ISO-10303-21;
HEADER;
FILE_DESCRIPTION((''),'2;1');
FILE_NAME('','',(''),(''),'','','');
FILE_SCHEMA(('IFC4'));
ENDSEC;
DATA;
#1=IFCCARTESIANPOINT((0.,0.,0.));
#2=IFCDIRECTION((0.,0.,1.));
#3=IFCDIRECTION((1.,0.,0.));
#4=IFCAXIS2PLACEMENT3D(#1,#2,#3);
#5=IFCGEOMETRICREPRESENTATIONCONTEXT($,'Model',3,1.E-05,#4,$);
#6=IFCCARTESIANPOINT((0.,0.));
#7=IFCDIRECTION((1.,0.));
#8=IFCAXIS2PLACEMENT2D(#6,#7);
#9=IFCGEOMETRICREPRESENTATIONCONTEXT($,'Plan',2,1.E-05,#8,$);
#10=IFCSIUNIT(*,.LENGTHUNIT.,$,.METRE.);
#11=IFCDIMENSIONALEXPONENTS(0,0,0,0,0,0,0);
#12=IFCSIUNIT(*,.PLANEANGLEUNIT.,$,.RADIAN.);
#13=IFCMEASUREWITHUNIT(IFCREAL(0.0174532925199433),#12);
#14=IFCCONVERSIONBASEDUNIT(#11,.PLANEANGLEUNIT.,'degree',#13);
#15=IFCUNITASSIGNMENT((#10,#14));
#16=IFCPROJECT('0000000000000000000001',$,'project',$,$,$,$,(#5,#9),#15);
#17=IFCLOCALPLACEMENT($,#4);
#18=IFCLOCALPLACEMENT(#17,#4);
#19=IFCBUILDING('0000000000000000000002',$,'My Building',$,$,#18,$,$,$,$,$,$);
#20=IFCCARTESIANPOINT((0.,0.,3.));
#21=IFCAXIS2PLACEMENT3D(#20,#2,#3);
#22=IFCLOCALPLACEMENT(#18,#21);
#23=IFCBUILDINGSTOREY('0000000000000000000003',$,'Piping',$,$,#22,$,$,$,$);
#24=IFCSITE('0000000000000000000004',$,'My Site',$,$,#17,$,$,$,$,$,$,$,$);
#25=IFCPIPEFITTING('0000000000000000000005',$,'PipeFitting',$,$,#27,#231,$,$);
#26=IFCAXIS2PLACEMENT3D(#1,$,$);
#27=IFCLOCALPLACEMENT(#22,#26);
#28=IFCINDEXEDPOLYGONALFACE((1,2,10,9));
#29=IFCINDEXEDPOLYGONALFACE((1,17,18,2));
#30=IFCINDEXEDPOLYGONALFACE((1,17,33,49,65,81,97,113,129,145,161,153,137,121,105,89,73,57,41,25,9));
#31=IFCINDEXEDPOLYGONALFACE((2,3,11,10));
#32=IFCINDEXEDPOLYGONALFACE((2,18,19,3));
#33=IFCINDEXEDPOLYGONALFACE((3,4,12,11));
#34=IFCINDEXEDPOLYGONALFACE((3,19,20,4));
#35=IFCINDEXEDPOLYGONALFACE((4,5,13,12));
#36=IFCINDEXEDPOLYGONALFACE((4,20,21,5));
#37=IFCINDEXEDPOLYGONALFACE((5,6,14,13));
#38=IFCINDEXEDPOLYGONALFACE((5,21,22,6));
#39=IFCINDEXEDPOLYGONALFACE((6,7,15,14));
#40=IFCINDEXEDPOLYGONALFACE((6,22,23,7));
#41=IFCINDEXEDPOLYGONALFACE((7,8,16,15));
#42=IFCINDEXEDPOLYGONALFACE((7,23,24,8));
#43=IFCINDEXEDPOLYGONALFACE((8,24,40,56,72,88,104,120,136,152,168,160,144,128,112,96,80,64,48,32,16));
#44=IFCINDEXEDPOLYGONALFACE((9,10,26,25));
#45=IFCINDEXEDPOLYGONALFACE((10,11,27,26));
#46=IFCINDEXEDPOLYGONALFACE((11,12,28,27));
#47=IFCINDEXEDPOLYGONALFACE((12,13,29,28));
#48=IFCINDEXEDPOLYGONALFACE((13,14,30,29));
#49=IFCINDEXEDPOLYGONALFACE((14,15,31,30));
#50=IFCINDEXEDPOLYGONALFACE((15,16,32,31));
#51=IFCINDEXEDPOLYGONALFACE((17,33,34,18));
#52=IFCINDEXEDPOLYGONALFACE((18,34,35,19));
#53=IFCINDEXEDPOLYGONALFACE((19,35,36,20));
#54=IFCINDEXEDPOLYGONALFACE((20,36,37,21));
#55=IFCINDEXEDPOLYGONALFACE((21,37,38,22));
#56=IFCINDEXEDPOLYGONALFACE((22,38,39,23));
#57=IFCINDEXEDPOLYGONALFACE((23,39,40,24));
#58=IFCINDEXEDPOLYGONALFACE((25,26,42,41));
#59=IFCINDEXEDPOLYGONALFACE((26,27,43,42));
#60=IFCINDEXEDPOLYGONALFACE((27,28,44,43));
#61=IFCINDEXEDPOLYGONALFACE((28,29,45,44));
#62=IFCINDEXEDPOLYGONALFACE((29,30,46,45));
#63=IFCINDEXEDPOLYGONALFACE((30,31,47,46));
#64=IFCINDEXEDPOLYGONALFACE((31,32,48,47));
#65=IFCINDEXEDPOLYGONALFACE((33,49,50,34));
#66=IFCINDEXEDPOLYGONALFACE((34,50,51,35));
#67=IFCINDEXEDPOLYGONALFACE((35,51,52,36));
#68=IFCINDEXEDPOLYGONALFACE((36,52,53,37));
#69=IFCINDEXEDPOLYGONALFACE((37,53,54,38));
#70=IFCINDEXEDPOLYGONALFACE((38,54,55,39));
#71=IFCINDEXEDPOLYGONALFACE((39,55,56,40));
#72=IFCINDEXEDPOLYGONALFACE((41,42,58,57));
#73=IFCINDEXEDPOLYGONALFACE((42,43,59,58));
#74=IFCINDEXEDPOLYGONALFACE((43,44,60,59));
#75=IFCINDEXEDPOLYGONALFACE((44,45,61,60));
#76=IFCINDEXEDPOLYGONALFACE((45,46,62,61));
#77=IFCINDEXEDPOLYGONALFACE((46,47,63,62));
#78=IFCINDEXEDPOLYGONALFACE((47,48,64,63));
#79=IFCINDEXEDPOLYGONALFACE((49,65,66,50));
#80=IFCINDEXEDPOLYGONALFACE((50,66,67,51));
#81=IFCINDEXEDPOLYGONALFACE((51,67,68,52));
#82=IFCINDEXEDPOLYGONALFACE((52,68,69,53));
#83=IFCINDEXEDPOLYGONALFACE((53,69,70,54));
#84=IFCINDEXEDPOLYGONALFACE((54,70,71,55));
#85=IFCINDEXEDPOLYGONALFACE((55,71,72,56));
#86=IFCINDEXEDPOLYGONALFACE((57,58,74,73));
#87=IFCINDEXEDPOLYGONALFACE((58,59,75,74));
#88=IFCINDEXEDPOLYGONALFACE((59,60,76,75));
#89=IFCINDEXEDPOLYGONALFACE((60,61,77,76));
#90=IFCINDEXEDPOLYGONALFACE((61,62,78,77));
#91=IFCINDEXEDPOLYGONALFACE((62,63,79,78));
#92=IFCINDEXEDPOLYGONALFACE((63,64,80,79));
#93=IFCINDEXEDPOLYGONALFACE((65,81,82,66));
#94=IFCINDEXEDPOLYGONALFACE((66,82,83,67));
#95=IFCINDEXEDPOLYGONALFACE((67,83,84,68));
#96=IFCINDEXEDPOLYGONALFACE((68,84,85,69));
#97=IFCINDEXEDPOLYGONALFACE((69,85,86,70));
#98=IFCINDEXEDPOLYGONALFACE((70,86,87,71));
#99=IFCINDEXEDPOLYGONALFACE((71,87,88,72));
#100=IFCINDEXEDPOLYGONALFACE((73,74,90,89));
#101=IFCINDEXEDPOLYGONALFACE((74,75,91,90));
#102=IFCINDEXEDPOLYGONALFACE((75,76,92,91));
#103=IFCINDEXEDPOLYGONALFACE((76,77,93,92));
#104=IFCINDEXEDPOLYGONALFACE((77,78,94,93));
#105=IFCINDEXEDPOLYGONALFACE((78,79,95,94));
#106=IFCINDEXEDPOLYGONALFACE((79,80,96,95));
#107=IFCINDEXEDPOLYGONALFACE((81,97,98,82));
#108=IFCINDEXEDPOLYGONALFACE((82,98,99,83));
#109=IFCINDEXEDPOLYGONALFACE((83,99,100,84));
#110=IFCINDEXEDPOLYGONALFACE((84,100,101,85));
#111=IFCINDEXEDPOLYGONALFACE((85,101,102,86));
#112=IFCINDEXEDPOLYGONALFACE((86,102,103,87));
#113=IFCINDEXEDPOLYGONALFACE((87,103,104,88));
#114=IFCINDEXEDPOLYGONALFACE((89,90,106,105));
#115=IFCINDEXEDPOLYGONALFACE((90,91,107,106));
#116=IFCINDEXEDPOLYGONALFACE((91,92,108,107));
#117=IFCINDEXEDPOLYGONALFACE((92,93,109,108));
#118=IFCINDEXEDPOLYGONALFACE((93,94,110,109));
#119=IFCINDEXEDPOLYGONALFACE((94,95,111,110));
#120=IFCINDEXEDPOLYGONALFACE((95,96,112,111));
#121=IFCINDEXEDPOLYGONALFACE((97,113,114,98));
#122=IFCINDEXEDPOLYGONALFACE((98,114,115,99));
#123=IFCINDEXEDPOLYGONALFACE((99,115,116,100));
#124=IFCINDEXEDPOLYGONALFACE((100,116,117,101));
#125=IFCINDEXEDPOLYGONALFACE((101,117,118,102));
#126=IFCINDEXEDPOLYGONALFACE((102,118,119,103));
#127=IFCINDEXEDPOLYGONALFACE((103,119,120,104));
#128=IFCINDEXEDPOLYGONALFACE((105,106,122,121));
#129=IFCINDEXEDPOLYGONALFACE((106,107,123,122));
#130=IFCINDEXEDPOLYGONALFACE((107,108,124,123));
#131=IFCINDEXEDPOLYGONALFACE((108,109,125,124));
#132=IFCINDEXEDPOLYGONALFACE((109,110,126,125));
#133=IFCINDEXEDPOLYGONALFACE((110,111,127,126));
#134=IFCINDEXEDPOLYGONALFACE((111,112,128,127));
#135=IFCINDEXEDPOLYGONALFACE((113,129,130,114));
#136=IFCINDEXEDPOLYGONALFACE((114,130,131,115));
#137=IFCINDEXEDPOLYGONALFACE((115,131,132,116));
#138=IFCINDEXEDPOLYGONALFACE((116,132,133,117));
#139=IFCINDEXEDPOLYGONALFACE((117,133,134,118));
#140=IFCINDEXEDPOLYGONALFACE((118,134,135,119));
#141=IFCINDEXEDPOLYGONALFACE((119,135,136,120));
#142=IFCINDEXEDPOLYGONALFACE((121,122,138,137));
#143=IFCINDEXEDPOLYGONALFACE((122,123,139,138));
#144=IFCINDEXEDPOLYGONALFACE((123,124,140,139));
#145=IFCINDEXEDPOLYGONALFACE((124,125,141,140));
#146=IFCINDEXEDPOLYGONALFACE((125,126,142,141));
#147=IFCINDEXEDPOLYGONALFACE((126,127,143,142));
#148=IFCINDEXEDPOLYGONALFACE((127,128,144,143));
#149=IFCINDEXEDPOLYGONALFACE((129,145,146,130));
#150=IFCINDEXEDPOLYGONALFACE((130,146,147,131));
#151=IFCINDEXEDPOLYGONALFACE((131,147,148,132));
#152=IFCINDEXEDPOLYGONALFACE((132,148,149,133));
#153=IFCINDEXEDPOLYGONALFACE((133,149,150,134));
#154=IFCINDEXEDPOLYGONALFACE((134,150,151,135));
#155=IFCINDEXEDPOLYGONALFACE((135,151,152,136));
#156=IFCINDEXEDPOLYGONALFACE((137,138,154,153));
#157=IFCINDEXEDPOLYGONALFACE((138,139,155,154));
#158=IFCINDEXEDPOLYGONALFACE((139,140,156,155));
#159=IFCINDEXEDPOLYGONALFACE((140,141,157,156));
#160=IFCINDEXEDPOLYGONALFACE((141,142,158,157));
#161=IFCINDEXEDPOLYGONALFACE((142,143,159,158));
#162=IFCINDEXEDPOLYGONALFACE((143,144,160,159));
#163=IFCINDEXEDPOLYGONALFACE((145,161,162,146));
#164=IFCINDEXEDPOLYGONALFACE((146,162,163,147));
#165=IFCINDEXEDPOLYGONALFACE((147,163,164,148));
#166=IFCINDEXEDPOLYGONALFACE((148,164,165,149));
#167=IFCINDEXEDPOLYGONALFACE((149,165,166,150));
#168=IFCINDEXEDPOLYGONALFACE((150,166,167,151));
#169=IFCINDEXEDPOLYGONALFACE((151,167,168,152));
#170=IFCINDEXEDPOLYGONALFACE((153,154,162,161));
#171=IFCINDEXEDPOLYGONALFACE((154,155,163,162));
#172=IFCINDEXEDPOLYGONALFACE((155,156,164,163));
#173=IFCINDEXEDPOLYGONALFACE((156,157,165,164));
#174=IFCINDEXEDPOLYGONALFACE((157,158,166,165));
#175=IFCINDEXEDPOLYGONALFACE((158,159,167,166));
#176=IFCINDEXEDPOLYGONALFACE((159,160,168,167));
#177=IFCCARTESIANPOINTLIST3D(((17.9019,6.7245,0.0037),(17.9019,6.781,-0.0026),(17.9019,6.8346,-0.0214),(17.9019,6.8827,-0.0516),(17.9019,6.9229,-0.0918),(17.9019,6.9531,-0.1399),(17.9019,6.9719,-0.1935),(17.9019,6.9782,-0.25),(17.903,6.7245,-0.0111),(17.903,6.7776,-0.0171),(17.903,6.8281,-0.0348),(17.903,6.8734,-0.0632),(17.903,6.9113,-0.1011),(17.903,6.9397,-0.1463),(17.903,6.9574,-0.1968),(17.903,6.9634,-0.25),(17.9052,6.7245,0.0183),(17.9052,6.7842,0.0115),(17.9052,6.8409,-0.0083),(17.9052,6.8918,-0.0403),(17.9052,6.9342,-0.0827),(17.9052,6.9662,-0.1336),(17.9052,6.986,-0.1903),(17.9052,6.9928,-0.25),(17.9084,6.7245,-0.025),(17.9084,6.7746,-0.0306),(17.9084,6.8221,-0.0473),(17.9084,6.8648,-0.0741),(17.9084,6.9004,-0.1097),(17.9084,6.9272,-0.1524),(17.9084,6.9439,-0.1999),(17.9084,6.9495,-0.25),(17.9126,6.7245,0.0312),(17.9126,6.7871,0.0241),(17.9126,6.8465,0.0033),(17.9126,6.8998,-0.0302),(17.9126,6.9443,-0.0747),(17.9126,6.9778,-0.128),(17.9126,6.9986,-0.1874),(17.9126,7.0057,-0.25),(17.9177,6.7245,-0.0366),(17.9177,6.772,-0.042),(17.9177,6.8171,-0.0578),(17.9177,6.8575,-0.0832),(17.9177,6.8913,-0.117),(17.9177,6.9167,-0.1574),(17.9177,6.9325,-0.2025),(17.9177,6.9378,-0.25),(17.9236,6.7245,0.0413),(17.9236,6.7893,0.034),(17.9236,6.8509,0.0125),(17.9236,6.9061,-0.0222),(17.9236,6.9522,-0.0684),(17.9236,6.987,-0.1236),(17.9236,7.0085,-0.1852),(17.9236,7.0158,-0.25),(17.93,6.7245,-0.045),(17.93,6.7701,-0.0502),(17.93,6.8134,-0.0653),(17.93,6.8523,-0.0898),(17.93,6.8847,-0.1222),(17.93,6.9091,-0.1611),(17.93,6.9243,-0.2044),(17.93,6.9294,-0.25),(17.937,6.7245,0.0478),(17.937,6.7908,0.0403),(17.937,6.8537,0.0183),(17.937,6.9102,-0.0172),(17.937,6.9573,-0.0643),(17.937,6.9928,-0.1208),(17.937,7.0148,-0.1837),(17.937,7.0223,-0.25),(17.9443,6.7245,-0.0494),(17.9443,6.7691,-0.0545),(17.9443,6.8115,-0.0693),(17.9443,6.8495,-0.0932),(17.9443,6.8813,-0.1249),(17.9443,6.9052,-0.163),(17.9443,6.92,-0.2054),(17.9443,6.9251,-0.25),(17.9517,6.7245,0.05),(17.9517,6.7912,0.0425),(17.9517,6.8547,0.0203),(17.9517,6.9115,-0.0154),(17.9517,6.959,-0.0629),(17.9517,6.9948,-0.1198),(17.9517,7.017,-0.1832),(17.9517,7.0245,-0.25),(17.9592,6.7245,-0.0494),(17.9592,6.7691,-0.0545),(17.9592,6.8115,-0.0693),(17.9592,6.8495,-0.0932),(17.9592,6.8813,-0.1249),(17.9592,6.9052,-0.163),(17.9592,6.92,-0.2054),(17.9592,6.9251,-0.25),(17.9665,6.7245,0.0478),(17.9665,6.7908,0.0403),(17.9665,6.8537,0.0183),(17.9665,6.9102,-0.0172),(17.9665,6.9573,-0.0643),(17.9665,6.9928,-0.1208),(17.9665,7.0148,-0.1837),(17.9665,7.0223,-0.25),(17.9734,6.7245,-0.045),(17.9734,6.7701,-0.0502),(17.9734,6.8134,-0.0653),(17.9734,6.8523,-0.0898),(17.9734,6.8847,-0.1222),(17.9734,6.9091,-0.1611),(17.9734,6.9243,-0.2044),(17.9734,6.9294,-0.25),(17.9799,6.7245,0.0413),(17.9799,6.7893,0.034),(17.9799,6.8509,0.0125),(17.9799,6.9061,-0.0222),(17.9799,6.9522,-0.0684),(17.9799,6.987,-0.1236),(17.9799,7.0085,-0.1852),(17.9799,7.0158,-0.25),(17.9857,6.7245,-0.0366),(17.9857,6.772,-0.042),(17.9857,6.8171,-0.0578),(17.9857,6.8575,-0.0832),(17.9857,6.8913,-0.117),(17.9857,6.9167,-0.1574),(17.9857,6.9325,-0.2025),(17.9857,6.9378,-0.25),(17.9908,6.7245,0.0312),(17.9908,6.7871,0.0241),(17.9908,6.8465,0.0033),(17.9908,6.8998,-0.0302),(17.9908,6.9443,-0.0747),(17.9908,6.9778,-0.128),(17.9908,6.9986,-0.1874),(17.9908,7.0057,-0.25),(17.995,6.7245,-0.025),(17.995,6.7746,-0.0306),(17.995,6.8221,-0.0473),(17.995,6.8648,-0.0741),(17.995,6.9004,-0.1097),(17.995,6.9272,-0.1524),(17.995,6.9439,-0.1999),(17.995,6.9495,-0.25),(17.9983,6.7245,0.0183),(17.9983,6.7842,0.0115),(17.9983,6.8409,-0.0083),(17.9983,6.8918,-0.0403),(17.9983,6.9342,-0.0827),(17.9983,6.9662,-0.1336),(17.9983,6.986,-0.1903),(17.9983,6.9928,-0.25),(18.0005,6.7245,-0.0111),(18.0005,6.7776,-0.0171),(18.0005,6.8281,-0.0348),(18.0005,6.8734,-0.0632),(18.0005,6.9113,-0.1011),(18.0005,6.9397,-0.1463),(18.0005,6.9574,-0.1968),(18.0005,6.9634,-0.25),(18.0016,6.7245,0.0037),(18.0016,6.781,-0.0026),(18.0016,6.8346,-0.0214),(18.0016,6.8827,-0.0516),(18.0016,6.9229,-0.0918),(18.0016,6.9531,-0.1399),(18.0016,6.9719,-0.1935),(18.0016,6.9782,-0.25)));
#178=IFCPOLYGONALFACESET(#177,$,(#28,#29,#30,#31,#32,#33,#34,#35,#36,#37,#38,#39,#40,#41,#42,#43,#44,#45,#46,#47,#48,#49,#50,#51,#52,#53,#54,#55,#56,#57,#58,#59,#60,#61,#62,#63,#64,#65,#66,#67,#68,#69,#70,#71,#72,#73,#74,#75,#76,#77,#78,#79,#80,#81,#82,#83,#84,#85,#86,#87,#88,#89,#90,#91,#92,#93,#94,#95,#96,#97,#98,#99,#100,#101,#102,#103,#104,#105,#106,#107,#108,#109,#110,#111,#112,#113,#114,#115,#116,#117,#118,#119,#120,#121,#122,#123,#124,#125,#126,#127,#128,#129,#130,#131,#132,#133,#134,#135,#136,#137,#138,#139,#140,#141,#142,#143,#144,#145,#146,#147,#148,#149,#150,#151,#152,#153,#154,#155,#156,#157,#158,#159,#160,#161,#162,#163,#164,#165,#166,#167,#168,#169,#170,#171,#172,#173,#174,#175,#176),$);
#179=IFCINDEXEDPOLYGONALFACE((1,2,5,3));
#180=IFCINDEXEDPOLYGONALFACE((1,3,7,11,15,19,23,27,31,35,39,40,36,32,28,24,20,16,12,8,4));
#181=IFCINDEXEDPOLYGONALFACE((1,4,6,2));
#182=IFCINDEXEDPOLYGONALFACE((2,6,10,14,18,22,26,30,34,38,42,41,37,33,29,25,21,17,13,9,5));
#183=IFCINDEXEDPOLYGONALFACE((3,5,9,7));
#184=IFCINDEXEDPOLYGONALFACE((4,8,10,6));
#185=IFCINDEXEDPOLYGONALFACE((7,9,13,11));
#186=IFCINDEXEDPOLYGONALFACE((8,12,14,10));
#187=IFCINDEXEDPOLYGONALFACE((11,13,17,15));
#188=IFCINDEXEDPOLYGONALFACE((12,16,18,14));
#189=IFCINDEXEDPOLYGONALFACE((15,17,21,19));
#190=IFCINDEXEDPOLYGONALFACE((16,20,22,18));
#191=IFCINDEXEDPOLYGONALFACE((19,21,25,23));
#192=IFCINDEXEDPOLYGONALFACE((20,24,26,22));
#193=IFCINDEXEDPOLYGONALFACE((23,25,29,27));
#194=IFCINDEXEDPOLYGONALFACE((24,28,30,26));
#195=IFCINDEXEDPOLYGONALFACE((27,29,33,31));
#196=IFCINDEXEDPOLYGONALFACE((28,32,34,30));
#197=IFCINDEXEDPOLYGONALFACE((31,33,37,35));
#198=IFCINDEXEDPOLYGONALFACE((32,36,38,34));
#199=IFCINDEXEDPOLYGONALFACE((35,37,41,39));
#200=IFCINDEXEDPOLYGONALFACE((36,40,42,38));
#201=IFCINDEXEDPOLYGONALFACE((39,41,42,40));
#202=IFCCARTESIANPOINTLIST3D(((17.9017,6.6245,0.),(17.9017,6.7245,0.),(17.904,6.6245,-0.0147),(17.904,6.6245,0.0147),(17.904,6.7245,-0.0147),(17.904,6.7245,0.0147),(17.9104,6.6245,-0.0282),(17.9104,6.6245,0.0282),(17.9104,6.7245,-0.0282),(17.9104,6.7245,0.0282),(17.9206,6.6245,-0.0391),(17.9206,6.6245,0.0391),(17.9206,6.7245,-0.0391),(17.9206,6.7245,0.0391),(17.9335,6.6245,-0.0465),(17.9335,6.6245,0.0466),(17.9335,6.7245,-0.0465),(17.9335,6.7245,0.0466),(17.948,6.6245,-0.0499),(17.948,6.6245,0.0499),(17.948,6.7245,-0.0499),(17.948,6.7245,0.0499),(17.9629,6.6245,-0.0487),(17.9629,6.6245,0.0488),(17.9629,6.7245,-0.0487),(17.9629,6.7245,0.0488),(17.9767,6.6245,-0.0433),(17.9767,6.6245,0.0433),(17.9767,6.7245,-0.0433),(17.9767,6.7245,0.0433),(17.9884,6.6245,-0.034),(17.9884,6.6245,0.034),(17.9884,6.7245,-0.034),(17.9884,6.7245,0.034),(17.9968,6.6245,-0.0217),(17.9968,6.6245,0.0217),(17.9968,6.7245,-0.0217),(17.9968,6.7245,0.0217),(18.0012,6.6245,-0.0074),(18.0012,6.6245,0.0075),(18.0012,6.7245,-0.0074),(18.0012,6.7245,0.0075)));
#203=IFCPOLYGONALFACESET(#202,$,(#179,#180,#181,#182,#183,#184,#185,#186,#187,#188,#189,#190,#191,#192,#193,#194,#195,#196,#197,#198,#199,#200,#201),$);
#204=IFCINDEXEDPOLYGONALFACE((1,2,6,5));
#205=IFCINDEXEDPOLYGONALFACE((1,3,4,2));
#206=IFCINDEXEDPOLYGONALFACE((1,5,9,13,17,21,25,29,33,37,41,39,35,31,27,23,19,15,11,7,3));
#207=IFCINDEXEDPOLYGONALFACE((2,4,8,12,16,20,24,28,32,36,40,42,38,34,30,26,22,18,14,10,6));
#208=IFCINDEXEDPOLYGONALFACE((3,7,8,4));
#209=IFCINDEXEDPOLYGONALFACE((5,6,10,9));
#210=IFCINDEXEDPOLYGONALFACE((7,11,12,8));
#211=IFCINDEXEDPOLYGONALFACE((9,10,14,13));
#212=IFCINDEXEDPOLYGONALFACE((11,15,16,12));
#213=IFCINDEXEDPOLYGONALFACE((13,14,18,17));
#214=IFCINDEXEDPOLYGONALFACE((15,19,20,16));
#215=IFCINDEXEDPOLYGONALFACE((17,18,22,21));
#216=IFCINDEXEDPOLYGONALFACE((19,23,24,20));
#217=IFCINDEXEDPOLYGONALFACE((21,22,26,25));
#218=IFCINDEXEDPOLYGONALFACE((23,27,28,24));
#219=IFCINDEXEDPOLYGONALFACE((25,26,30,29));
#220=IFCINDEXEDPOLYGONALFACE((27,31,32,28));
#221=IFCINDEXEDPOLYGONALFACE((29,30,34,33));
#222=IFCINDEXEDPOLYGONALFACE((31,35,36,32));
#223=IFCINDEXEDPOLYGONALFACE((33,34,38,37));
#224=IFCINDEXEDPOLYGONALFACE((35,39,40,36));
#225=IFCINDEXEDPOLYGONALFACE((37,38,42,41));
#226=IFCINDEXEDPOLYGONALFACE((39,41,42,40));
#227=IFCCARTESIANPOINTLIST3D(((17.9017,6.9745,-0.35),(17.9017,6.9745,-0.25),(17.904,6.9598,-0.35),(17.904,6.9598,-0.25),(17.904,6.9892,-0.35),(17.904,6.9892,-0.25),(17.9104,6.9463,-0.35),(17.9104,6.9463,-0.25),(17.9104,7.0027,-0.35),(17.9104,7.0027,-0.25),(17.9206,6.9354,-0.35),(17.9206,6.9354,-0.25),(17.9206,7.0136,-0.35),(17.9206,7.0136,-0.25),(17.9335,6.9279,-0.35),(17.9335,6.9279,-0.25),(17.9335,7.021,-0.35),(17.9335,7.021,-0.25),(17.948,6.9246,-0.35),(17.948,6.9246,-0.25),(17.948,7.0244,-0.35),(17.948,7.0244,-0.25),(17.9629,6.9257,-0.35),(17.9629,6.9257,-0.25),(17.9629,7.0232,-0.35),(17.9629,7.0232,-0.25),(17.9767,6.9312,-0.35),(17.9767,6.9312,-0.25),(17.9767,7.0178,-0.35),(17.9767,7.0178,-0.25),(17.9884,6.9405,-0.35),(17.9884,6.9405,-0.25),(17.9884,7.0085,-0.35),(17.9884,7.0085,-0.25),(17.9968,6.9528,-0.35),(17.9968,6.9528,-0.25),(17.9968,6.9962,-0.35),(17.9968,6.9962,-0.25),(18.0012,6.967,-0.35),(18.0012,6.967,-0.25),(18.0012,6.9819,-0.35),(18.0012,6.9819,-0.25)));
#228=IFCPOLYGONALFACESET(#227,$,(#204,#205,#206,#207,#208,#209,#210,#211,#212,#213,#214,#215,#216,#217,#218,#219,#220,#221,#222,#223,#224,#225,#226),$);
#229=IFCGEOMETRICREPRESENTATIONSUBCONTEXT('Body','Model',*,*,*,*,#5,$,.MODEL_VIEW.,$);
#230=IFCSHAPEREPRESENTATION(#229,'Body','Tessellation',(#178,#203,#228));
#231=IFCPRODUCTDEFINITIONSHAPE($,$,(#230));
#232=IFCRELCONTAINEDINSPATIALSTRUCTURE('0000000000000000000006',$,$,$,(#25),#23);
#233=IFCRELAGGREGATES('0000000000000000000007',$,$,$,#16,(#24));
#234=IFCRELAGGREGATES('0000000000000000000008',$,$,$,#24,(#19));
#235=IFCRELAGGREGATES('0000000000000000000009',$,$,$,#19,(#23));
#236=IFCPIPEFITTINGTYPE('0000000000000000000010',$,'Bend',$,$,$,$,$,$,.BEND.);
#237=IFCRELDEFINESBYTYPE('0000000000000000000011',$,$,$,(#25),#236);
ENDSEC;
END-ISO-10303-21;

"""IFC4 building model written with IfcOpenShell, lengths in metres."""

from ifc_helpers import new_model, entity, si_unit, converted_unit, frame, origin_with_axes, origin_2d_with_axis, place, context, subcontext, project, spatial, circle, extrude, source, transform, mapped, type_object, type_shapes, element, save


model = new_model("IFC4")

# Units and contexts
model_context = context("Model", 3, precision=1e-05, world=origin_with_axes())
plan_context = context("Plan", 2, precision=1e-05, world=origin_2d_with_axis())
body_context = subcontext(model_context, "Body", "Model", "MODEL_VIEW")
ifc_project = project(units=[si_unit("LENGTHUNIT", "METRE"), converted_unit("PLANEANGLEUNIT", "degree", entity("IfcReal", 0.0174532925199433), si_unit("PLANEANGLEUNIT", "RADIAN"), dimensions=[0, 0, 0, 0, 0, 0, 0])], contexts=[model_context, plan_context])

# Site, building, storey
site_placement = place(None, origin_with_axes())
site = spatial("IfcSite", under=ifc_project, at=site_placement, Name="My Site")
building_placement = place(site_placement, origin_with_axes())
building = spatial("IfcBuilding", under=site, at=building_placement, Name="My Building")
storey_placement = place(building_placement, frame((0.0, 0.0, 3.0), z_axis=(0.0, 0.0, 1.0), x_axis=(1.0, 0.0, 0.0)))
storey = spatial("IfcBuildingStorey", under=building, at=storey_placement, Name="Piping")

# Pipe fitting
pipe_fitting_type = type_object("IfcPipeFittingType", Name="Bend", PredefinedType="BEND")
shared_shape = source(origin_with_axes(), body_context, "Body", "SolidModel", [
    entity("IfcSweptDiskSolid", entity("IfcIndexedPolyCurve", entity("IfcCartesianPointList3D", [[0.0, 0.0, 0.1], [0.0, -0.0732, 0.2768], [0.0, -0.25, 0.35]]), [entity("IfcArcIndex", [1, 2, 3])]), 0.05),
    extrude(circle(Radius=0.05), origin_with_axes(), (0.0, 0.0, 1.0), 0.1),
    extrude(circle(Radius=0.05), frame((0.0, -0.25, 0.35), z_axis=(0.0, -1.0, 0.0), x_axis=(1.0, 0.0, 0.0)), (0.0, 0.0, 1.0), 0.1),
])
type_shapes(pipe_fitting_type, [shared_shape])
for number, where, z_axis, x_axis, name in (
    (1, (17.9517, 6.6245, 0.0), (0.0, 1.0, 0.0), (-1.0, 0.0, 0.0), "PipeFitting"),
):
    element("IfcPipeFitting", number, at=place(storey_placement, frame(where, z_axis=z_axis, x_axis=x_axis)), inside=storey, type_object=pipe_fitting_type, Name=name, context=body_context, shape_type="MappedRepresentation", body=[
        mapped(shared_shape, transform((0.0, 0.0, 0.0), x_axis=(1.0, 0.0, 0.0), y_axis=(0.0, 1.0, 0.0), z_axis=(0.0, 0.0, 1.0), scale=1.0)),
    ])

save(model, "model.ifc")
